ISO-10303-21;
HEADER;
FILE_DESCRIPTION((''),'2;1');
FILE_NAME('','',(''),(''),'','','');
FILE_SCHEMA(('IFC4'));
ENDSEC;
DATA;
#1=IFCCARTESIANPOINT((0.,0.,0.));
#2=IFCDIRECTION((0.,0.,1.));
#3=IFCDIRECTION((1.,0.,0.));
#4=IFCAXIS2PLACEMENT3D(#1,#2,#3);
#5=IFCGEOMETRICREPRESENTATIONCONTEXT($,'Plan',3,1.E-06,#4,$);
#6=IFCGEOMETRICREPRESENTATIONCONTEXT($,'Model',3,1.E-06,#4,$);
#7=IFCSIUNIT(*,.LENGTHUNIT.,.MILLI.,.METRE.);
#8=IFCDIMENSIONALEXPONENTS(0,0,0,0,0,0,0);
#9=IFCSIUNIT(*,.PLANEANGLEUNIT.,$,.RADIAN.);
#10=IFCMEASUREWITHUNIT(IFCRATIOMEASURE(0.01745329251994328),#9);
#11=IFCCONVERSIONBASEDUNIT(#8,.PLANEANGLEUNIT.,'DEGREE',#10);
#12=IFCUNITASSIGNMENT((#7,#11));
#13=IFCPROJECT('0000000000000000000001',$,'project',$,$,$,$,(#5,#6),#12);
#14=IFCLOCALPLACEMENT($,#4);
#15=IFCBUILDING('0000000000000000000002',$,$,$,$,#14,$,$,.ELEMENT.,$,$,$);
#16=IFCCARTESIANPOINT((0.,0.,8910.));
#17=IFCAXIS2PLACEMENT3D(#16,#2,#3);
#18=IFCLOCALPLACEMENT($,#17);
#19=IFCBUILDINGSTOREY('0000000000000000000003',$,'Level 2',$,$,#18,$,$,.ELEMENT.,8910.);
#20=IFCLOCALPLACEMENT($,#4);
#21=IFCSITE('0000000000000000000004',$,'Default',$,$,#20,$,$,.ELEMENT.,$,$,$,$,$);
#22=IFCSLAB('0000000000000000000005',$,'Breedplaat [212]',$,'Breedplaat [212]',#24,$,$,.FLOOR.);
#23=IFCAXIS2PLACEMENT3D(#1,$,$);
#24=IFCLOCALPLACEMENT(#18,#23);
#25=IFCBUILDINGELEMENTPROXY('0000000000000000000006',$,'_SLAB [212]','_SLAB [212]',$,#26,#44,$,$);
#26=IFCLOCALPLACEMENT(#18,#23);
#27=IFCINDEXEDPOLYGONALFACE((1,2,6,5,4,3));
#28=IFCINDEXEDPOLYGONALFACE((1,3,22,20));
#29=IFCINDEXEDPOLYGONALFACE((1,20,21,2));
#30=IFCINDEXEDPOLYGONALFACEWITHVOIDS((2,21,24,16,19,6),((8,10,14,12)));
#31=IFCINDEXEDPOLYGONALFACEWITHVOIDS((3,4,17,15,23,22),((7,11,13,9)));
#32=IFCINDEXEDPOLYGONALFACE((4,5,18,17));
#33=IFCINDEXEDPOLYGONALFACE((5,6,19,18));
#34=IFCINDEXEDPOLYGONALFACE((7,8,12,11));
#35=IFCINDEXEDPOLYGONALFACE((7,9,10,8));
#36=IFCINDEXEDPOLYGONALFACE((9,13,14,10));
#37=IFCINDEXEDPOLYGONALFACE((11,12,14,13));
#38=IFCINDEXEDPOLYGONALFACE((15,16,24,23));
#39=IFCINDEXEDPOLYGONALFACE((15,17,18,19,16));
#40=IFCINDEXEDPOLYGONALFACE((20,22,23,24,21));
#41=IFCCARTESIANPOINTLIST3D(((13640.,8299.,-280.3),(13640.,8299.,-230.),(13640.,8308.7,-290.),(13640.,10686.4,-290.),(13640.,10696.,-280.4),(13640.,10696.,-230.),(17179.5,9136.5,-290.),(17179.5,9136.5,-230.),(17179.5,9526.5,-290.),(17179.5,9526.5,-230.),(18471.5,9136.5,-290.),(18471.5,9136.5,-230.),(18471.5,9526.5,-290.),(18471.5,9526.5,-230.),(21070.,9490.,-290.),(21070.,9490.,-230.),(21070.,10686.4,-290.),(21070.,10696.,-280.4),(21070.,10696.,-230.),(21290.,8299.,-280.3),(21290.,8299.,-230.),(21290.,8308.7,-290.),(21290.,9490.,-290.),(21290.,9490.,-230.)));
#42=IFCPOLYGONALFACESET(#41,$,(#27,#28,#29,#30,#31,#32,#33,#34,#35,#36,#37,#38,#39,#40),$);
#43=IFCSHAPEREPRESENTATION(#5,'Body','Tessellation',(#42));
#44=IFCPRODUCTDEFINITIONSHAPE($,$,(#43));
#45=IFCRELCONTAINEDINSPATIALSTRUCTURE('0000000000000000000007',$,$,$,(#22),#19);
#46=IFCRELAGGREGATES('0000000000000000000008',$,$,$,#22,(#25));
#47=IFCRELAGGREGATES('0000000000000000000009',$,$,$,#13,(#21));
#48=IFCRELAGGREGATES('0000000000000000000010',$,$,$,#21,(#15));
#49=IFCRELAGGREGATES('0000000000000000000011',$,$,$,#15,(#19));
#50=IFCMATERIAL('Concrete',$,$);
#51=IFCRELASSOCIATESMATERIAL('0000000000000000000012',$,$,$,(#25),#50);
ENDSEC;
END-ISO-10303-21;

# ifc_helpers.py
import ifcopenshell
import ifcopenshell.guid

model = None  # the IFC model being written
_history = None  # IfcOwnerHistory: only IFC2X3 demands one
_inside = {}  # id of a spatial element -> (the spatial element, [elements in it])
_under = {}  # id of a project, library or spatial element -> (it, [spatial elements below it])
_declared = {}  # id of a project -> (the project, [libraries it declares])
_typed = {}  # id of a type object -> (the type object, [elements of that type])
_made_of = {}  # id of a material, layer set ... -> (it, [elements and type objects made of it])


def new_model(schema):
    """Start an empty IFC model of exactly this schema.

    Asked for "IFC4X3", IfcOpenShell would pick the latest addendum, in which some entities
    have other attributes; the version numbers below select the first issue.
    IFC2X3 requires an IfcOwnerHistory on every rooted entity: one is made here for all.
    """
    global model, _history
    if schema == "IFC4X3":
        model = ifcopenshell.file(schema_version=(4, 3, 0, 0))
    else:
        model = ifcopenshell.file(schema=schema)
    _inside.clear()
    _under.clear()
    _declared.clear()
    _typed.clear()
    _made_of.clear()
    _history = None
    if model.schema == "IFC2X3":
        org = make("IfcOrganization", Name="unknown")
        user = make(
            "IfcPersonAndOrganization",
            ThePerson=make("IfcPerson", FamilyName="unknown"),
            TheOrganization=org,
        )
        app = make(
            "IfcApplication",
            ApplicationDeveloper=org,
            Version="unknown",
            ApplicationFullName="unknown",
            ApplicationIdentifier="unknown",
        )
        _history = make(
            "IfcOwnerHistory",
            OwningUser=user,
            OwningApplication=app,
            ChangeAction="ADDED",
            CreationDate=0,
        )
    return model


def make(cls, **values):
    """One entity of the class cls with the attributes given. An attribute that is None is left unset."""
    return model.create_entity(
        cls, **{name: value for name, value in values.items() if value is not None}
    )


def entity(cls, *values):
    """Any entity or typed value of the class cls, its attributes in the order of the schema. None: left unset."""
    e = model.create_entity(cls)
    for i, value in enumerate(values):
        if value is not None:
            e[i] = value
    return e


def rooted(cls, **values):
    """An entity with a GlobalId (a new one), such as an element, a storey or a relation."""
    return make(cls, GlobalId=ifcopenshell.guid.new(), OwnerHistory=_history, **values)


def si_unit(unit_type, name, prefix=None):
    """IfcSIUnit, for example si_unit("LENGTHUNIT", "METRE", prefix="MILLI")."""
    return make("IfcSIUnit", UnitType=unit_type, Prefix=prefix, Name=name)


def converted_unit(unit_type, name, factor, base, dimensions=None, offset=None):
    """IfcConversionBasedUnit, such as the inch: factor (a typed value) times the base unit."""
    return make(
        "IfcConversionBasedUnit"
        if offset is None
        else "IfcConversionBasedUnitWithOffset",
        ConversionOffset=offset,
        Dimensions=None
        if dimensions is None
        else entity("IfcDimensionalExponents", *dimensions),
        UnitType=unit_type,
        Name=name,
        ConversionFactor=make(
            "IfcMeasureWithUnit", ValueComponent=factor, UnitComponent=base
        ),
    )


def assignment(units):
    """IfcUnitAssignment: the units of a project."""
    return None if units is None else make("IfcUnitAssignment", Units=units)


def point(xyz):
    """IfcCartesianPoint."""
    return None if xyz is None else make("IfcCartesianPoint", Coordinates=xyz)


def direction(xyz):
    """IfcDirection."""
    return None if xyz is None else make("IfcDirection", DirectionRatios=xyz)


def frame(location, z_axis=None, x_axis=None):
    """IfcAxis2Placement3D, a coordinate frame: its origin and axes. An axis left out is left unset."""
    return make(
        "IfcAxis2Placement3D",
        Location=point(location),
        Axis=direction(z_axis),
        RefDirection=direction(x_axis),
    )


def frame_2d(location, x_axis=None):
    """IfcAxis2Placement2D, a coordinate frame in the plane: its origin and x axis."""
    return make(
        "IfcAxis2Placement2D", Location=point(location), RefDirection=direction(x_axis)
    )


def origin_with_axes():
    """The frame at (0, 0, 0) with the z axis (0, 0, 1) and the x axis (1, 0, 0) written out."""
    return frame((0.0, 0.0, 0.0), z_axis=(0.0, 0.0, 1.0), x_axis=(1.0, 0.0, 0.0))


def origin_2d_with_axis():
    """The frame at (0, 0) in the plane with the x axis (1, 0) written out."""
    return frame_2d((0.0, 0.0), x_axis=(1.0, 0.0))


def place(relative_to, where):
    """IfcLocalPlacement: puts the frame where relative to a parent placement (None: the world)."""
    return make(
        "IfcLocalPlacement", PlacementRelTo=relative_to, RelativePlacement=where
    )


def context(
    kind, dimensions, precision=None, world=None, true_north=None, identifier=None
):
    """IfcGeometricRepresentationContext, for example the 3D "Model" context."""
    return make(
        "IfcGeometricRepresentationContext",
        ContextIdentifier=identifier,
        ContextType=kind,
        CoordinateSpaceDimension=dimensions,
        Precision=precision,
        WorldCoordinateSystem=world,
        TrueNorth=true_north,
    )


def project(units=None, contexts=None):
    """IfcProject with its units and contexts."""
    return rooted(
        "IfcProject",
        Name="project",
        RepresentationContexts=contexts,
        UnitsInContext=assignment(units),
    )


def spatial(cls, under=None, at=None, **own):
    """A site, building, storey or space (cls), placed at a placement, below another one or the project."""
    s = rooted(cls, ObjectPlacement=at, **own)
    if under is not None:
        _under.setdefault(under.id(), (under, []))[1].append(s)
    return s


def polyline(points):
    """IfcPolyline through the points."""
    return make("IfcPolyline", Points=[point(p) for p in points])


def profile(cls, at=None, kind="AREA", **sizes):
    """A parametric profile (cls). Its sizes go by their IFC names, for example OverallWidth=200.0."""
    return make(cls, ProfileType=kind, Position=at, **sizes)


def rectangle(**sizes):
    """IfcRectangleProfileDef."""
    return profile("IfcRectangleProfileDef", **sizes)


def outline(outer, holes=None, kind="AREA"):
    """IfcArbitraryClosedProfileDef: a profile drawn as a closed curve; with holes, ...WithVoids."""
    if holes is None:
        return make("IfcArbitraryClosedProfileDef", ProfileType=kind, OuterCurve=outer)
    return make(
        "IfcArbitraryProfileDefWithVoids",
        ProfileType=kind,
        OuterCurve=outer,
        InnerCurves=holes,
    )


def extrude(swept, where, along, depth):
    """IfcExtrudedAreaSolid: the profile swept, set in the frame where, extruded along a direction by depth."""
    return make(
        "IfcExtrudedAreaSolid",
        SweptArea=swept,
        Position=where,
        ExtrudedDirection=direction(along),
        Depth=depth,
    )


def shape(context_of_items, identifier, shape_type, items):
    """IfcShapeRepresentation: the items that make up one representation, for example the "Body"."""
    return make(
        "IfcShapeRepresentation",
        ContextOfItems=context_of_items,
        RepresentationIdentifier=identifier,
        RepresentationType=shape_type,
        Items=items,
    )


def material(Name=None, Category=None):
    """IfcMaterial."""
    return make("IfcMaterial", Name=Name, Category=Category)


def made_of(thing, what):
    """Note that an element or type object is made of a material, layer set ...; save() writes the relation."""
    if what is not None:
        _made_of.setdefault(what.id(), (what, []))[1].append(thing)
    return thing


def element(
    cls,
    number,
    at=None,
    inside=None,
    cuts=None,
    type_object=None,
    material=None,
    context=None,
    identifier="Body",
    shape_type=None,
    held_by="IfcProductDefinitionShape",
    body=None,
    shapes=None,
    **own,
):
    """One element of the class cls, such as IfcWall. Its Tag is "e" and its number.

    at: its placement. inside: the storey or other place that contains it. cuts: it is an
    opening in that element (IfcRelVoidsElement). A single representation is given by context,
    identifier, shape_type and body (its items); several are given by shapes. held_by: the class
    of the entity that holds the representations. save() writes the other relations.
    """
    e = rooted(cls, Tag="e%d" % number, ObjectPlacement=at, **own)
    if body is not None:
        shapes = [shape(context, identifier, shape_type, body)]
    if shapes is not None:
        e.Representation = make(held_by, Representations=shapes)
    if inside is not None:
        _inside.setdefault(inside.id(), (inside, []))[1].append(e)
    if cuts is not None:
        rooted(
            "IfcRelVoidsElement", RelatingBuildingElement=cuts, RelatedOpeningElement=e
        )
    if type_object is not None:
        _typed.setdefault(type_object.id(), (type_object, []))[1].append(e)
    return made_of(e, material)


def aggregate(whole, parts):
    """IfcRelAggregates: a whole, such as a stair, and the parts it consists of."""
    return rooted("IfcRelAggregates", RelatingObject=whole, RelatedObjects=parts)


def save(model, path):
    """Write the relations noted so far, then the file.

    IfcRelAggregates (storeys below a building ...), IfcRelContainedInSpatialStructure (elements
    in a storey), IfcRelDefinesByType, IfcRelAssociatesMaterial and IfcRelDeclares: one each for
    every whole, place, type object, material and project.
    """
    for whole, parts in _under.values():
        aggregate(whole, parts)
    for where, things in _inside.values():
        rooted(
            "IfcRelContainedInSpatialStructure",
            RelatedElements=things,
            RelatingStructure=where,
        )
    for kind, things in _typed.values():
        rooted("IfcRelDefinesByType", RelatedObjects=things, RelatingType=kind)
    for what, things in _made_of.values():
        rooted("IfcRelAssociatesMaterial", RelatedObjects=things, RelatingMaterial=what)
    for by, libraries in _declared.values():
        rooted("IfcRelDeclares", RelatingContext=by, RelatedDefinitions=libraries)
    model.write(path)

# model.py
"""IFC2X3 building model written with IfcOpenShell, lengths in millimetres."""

from ifc_helpers import new_model, entity, si_unit, converted_unit, frame, origin_with_axes, origin_2d_with_axis, place, context, project, spatial, polyline, rectangle, outline, extrude, material, element, aggregate, save


model = new_model("IFC2X3")

# Units and contexts
plan_context = context("Plan", 3, precision=1e-06, world=origin_with_axes())
model_context = context("Model", 3, precision=1e-06, world=origin_with_axes())
ifc_project = project(units=[si_unit("LENGTHUNIT", "METRE", prefix="MILLI"), converted_unit("PLANEANGLEUNIT", "DEGREE", entity("IfcRatioMeasure", 0.01745329251994328), si_unit("PLANEANGLEUNIT", "RADIAN"), dimensions=[0, 0, 0, 0, 0, 0, 0])], contexts=[plan_context, model_context])

# Site, building, storey
site_placement = place(None, origin_with_axes())
site = spatial("IfcSite", under=ifc_project, at=site_placement, Name="Default", CompositionType="ELEMENT")
building_placement = place(None, origin_with_axes())
building = spatial("IfcBuilding", under=site, at=building_placement, CompositionType="ELEMENT")
storey_placement = place(None, frame((0.0, 0.0, 8910.0), z_axis=(0.0, 0.0, 1.0), x_axis=(1.0, 0.0, 0.0)))
storey = spatial("IfcBuildingStorey", under=building, at=storey_placement, Name="Level 2", CompositionType="ELEMENT", Elevation=8910.0)

# Slab, building element proxy, openings
slab_1_placement = place(None, frame((13640.0, 8299.0, 8620.0), z_axis=(0.0, 0.0, 1.0), x_axis=(1.0, 0.0, 0.0)))
slab_1 = element("IfcSlab", 1, at=slab_1_placement, inside=storey, Name="Breedplaat [212]", ObjectType="Breedplaat [212]", PredefinedType="FLOOR")
ifc_material = material(Name="Concrete")
proxy_1_placement = place(slab_1_placement, origin_with_axes())
proxy_1 = element("IfcBuildingElementProxy", 2, at=proxy_1_placement, material=ifc_material, Name="_SLAB [212]", Description="_SLAB [212]", context=plan_context, shape_type="SweptSolid", body=[
    extrude(outline(polyline([(7650.0, 1191.0), (7430.0, 1191.0), (7430.0, 2397.0), (0.0, 2397.0), (0.0, 0.0), (7650.0, 0.0), (7650.0, 1191.0)])), origin_with_axes(), (0.0, 0.0, 1.0), 60.0),
])
opening_1_placement = place(slab_1_placement, frame((3539.5, 837.5, 0.0), z_axis=(0.0, 0.0, 1.0), x_axis=(1.0, 0.0, 0.0)))
element("IfcOpeningElement", 3, at=opening_1_placement, cuts=proxy_1, ObjectType="Opening", context=plan_context, shape_type="SolidModel", body=[
    extrude(rectangle(XDim=1292.0, YDim=390.0, at=origin_2d_with_axis()), frame((646.0, 195.0, 0.0), z_axis=(0.0, 0.0, 1.0), x_axis=(1.0, 0.0, 0.0)), (0.0, 0.0, 1.0), 60.0),
])
opening_2_placement = place(None, frame((13640.0, 8299.0, 8620.0), z_axis=(0.0, 0.0, 1.0), x_axis=(1.0, 0.0, 0.0)))
element("IfcOpeningElement", 4, at=opening_2_placement, cuts=proxy_1, ObjectType="Opening", context=plan_context, shape_type="SweptSolid", body=[
    extrude(outline(polyline([(-0.1, -0.1), (-0.1, 10.0), (10.0, -0.1), (-0.1, -0.1)])), frame((-1.2, -0.1, -0.1), z_axis=(1.0, 0.0, 0.0), x_axis=(0.0, 1.0, 0.0)), (0.0, 0.0, 1.0), 7652.2),
])
opening_3_placement = place(None, frame((13640.0, 8299.0, 8620.0), z_axis=(0.0, 0.0, 1.0), x_axis=(1.0, 0.0, 0.0)))
element("IfcOpeningElement", 5, at=opening_3_placement, cuts=proxy_1, ObjectType="Opening", context=plan_context, shape_type="SweptSolid", body=[
    extrude(outline(polyline([(-0.1, -0.1), (-0.1, 10.0), (10.0, -0.1), (-0.1, -0.1)])), frame((7431.2, 2397.2, -0.1), z_axis=(-1.0, 0.0, 0.0), x_axis=(0.0, -1.0, 0.0)), (0.0, 0.0, 1.0), 7432.2),
])
aggregate(slab_1, [proxy_1])

save(model, "model.ifc")
